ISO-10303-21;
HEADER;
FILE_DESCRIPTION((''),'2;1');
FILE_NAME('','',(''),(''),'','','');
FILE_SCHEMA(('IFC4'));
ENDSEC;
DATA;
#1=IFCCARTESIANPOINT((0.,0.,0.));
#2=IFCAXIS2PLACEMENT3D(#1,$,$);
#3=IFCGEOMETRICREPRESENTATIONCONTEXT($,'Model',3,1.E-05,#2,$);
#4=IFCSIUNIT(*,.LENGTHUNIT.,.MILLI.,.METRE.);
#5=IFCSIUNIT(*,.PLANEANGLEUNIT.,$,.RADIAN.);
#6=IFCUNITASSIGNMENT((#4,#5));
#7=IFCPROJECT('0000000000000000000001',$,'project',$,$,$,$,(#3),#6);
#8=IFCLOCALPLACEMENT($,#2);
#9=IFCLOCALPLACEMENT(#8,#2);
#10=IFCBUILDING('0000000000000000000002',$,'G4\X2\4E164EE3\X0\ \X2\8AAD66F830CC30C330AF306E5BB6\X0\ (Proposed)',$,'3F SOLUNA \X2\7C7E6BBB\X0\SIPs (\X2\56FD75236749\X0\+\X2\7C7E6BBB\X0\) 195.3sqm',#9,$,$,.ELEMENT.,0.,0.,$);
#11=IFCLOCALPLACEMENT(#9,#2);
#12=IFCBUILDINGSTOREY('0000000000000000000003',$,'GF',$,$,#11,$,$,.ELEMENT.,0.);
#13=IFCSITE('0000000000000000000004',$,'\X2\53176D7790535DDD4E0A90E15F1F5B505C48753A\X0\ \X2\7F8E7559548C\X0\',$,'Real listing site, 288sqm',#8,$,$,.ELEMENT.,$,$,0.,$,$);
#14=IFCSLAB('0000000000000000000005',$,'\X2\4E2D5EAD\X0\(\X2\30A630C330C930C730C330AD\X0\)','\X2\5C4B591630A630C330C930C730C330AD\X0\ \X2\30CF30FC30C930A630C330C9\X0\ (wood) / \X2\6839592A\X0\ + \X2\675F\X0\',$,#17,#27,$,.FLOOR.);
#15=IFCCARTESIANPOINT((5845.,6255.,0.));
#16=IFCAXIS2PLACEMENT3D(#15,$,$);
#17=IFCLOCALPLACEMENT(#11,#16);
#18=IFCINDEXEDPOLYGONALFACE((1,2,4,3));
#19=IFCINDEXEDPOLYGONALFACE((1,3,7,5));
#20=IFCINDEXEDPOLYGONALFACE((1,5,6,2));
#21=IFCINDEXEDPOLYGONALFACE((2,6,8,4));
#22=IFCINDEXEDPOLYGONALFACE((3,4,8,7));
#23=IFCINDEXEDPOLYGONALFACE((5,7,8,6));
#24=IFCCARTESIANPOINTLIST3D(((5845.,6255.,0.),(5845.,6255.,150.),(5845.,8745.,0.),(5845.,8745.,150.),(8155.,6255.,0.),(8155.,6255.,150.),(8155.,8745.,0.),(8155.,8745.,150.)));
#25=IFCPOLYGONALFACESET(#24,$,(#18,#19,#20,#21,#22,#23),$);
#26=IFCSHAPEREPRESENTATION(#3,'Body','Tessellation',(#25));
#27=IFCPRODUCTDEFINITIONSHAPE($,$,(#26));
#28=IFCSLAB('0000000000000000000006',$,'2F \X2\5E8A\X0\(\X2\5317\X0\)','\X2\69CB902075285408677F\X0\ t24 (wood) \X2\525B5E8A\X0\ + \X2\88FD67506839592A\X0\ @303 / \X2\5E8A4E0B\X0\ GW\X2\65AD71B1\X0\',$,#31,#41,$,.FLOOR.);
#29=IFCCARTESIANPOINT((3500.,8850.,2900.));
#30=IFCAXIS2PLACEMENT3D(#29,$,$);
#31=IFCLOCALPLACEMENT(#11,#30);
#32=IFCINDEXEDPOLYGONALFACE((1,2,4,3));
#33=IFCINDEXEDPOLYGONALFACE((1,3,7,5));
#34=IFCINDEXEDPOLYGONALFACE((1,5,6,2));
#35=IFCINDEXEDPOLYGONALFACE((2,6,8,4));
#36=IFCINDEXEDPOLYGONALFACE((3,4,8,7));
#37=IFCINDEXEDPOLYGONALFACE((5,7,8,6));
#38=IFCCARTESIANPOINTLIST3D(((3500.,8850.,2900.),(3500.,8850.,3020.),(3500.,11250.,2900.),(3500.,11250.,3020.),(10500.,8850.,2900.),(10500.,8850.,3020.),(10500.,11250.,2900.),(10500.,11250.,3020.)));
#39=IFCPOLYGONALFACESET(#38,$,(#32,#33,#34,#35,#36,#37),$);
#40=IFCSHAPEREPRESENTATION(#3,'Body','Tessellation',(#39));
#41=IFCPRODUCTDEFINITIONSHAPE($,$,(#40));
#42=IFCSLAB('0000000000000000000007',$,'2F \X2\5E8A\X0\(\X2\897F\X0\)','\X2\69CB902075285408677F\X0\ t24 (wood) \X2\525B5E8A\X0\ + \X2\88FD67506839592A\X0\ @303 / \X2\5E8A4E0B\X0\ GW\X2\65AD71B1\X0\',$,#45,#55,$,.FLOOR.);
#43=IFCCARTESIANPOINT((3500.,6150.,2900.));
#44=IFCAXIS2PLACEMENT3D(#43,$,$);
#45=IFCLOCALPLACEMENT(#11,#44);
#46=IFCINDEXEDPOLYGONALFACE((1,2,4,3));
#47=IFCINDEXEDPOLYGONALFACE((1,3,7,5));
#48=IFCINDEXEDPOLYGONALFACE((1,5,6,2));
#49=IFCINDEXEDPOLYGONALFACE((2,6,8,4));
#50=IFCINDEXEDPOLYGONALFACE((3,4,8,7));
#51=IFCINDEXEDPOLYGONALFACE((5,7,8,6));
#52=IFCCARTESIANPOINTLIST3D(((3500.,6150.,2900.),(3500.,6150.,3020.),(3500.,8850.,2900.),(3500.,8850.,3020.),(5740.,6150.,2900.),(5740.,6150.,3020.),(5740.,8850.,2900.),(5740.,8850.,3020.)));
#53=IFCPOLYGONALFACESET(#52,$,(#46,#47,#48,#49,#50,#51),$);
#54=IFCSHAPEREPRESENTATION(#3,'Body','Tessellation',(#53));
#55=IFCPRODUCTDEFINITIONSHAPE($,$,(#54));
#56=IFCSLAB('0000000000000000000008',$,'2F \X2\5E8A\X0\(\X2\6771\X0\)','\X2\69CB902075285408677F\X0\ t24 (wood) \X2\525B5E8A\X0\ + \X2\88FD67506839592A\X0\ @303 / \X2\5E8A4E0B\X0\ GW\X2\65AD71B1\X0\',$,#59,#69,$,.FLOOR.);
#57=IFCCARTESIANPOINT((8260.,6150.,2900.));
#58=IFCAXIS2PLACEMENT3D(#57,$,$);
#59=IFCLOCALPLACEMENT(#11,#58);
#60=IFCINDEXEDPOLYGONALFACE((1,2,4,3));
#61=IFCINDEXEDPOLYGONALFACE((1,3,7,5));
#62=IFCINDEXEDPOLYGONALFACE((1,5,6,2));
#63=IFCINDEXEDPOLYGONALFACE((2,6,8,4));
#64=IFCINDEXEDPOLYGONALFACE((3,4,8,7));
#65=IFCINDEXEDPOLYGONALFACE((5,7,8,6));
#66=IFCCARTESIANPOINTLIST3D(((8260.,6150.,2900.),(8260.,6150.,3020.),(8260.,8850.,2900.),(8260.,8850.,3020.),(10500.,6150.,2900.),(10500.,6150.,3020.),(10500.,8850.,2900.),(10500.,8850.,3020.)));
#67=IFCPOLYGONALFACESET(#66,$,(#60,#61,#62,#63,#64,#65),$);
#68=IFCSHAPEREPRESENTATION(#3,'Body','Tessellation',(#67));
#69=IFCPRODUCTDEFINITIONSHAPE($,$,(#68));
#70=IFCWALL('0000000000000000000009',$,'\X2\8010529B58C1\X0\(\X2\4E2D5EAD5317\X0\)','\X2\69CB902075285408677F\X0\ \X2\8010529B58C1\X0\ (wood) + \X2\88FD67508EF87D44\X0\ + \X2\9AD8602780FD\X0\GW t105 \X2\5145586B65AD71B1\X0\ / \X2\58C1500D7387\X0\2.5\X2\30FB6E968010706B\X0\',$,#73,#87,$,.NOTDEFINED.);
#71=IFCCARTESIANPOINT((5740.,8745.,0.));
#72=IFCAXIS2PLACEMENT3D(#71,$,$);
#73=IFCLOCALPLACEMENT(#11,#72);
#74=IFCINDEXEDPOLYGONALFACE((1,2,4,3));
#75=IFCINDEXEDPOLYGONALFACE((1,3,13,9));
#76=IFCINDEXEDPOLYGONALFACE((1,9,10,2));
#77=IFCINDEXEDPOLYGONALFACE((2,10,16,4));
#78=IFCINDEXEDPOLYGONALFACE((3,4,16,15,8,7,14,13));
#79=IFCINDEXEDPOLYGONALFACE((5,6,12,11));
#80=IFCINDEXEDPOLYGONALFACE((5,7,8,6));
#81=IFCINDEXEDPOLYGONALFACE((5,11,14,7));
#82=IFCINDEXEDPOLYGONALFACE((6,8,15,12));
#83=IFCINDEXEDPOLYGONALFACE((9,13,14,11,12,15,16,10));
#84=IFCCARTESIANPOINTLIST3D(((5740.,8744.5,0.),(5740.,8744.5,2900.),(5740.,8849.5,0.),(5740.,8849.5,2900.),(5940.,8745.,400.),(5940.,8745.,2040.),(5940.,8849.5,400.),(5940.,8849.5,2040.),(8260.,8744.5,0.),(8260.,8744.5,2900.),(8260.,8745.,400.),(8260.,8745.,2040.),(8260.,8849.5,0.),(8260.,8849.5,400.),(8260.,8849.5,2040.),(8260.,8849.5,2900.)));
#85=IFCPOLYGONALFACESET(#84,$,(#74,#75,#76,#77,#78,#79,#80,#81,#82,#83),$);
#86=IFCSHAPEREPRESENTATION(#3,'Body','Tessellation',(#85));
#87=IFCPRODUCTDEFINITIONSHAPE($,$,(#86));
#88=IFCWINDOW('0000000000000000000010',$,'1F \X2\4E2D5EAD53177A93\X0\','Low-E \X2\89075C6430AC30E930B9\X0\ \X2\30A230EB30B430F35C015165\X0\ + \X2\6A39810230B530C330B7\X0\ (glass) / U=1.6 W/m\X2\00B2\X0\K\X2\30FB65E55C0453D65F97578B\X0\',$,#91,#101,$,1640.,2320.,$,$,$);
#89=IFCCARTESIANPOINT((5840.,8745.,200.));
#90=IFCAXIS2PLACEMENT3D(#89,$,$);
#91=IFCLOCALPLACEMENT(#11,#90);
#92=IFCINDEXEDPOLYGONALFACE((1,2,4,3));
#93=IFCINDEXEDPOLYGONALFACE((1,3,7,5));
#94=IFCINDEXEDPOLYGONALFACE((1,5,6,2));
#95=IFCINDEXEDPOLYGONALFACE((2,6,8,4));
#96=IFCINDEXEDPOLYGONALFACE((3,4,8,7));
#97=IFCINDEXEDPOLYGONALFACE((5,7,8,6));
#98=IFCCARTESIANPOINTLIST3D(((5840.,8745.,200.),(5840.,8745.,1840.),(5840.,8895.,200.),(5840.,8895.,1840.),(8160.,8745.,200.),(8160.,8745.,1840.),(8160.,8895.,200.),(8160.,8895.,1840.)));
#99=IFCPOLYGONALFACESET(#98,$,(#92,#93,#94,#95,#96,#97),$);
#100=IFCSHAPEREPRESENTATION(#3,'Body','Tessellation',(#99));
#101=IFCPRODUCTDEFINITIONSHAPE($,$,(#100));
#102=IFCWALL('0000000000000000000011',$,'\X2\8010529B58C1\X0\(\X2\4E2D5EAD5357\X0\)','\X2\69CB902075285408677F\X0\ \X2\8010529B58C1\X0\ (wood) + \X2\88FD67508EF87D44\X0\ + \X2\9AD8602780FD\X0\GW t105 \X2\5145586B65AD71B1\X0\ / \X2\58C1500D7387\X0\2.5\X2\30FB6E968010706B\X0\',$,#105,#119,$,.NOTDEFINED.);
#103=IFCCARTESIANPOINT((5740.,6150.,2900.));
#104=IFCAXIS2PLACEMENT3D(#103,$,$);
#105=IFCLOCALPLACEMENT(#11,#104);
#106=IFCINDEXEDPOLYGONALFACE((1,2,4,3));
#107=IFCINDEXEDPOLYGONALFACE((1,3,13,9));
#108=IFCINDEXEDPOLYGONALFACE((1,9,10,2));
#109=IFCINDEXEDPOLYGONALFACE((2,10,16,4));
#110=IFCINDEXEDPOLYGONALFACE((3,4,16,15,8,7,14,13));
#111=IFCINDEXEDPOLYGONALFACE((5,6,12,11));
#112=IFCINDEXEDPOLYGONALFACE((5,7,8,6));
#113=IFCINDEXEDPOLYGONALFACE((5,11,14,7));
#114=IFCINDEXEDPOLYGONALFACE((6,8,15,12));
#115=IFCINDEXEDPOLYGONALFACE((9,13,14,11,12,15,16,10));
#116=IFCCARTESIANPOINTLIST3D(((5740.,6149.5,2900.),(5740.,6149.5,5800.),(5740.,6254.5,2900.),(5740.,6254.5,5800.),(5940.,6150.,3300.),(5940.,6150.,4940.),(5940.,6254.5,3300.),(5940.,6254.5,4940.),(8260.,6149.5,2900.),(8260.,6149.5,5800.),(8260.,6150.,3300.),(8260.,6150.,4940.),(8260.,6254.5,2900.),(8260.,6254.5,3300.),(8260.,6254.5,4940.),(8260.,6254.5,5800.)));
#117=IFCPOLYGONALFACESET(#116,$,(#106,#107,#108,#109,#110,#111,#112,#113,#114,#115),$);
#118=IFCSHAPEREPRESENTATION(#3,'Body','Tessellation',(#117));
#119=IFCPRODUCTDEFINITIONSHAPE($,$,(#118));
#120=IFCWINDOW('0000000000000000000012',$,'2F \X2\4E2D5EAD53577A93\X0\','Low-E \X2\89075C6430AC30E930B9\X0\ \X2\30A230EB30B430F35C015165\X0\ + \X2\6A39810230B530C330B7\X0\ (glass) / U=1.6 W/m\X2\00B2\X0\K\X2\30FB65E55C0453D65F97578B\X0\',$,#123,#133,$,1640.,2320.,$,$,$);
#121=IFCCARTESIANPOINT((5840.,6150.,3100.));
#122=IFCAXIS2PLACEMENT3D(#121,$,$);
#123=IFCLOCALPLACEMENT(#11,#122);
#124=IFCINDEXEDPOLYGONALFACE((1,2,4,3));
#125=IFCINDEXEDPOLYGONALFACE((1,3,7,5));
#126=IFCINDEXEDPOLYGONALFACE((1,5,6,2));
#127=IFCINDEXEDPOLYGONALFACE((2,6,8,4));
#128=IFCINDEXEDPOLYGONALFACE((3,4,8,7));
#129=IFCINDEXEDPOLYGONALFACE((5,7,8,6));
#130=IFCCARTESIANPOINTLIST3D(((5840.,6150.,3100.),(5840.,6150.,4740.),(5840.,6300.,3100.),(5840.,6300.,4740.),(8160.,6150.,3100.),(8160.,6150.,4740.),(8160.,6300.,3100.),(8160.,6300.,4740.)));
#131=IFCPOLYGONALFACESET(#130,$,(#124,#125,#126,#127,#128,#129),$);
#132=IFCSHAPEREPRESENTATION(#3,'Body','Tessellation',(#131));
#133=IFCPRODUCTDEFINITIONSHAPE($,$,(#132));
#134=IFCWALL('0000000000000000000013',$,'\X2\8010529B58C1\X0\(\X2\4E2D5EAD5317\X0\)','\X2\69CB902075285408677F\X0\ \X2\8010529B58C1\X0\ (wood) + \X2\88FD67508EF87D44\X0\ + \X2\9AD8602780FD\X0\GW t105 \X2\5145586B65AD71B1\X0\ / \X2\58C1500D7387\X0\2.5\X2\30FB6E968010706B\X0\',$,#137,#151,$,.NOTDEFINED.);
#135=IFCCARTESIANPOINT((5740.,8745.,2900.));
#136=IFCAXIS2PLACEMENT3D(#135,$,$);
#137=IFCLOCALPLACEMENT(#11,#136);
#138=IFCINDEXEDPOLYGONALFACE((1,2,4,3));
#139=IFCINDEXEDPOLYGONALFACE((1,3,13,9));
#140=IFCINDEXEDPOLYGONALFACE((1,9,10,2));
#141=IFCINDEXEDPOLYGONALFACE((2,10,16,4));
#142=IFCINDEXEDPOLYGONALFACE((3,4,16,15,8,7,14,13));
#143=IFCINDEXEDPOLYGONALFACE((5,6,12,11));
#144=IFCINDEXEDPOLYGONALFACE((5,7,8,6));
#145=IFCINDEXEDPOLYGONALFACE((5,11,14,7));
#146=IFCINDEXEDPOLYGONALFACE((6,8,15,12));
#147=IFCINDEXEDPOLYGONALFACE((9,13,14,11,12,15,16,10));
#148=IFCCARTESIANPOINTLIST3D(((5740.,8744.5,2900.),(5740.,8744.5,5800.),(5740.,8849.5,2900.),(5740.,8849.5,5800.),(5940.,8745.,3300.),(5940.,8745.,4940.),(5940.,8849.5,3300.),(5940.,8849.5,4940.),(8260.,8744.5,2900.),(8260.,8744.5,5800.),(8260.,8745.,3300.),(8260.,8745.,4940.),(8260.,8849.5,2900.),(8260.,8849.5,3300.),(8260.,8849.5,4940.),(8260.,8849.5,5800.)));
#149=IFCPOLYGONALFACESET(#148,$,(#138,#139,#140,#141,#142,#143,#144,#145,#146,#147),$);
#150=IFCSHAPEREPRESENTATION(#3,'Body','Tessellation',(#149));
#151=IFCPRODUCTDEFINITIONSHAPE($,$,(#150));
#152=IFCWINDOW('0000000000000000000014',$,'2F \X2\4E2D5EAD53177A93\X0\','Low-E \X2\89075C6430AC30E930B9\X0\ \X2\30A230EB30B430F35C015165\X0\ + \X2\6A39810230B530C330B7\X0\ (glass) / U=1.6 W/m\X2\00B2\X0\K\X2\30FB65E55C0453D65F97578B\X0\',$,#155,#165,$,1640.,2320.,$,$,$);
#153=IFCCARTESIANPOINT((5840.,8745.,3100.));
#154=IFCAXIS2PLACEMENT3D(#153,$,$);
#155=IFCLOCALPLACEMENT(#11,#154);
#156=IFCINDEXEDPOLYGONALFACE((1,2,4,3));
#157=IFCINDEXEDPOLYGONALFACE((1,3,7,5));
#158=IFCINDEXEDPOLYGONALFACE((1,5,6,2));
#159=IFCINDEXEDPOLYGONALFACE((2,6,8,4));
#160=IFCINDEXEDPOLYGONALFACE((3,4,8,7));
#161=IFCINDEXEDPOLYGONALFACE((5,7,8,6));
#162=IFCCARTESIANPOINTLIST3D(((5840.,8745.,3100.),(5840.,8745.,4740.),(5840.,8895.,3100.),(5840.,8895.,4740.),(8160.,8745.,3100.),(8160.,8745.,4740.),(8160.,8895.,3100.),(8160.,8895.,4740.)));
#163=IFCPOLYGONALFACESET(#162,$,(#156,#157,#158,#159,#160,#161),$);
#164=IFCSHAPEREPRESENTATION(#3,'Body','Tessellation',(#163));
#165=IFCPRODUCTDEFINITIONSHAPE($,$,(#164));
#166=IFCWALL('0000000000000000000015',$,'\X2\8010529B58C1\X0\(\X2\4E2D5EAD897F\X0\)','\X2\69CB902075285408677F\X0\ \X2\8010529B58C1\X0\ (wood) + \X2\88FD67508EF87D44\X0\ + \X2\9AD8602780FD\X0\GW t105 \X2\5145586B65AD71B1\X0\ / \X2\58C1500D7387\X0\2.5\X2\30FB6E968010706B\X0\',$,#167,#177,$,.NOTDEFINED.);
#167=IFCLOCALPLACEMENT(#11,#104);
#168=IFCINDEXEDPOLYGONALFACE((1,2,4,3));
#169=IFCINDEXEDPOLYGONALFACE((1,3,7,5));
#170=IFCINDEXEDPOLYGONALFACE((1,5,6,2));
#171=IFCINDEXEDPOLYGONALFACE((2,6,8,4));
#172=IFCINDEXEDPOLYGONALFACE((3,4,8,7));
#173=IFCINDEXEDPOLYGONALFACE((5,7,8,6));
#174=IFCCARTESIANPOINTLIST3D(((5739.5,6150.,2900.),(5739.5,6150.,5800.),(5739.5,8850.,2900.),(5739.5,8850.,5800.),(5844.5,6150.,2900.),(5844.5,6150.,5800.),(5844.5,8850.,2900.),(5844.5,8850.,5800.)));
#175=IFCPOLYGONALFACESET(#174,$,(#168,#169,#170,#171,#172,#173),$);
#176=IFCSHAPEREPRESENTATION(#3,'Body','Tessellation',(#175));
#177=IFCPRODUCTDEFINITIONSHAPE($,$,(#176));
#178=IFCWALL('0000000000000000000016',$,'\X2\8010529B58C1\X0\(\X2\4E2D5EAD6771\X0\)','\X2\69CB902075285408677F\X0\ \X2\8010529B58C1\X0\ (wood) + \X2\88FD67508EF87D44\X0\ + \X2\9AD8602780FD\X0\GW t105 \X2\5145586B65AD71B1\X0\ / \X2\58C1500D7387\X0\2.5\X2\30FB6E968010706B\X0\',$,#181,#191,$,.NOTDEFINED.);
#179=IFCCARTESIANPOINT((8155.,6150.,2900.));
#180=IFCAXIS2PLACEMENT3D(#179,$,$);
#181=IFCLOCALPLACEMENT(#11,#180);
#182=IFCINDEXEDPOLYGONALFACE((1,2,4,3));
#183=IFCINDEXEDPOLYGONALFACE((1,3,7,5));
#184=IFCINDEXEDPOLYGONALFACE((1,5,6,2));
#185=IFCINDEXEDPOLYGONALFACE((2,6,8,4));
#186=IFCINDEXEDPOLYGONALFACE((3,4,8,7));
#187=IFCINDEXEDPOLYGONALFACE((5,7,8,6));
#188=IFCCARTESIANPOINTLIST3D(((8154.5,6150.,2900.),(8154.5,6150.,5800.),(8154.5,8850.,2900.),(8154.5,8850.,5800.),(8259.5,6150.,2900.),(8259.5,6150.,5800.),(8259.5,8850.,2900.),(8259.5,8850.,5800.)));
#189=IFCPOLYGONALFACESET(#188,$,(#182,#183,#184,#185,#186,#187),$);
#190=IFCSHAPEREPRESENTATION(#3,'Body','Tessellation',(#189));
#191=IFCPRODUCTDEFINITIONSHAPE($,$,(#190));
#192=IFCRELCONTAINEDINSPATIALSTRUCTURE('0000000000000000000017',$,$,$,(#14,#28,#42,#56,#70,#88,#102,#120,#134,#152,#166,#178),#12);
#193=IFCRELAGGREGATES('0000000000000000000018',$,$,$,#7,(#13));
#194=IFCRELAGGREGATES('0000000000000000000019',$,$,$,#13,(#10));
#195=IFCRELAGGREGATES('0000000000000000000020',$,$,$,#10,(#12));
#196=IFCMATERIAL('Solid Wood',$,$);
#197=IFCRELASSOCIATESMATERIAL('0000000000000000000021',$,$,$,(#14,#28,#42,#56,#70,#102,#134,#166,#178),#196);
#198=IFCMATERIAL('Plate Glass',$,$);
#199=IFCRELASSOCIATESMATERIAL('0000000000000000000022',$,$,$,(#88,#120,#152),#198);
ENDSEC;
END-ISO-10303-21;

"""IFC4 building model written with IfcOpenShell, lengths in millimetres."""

from ifc_helpers import new_model, si_unit, frame, frame_2d, origin, place, context, project, spatial, rectangle, extrude, material, element, fill, save


model = new_model("IFC4")

# Units and contexts
model_context = context("Model", 3, precision=1e-05, world=origin())
ifc_project = project(units=[si_unit("LENGTHUNIT", "METRE", prefix="MILLI"), si_unit("PLANEANGLEUNIT", "RADIAN")], contexts=[model_context])

# Site, building, storey
site_placement = place(None, origin())
site = spatial("IfcSite", under=ifc_project, at=site_placement, Name="北海道川上郡弟子屈町 美留和", ObjectType="Real listing site, 288sqm", CompositionType="ELEMENT", RefElevation=0.0)
building_placement = place(site_placement, origin())
building = spatial("IfcBuilding", under=site, at=building_placement, Name="G4世代 読書ヌックの家 (Proposed)", ObjectType="3F SOLUNA 籾殻SIPs (国産杉+籾殻) 195.3sqm", CompositionType="ELEMENT", ElevationOfRefHeight=0.0, ElevationOfTerrain=0.0)
storey_placement = place(building_placement, origin())
storey = spatial("IfcBuildingStorey", under=building, at=storey_placement, Name="GF", CompositionType="ELEMENT", Elevation=0.0)

# Slabs
ifc_material_1 = material(Name="Solid Wood")
slab_1_placement = place(storey_placement, frame((5845.0, 6255.0, 0.0)))
element("IfcSlab", 1, at=slab_1_placement, inside=storey, material=ifc_material_1, Name="中庭(ウッドデッキ)", Description="屋外ウッドデッキ ハードウッド (wood) / 根太 + 束", PredefinedType="FLOOR", context=model_context, shape_type="SweptSolid", body=[
    extrude(rectangle(XDim=2310.0, YDim=2490.0, at=frame_2d((1155.0, 1245.0))), frame((5845.0, 6255.0, 0.0)), (0.0, 0.0, 1.0), 150.0),
])
slab_2_placement = place(storey_placement, frame((3500.0, 8850.0, 2900.0)))
element("IfcSlab", 2, at=slab_2_placement, inside=storey, material=ifc_material_1, Name="2F 床(北)", Description="構造用合板 t24 (wood) 剛床 + 製材根太 @303 / 床下 GW断熱", PredefinedType="FLOOR", context=model_context, shape_type="SweptSolid", body=[
    extrude(rectangle(XDim=7000.0, YDim=2400.0, at=frame_2d((3500.0, 1200.0))), frame((3500.0, 8850.0, 2900.0)), (0.0, 0.0, 1.0), 120.0),
])
slab_3_placement = place(storey_placement, frame((3500.0, 6150.0, 2900.0)))
element("IfcSlab", 3, at=slab_3_placement, inside=storey, material=ifc_material_1, Name="2F 床(西)", Description="構造用合板 t24 (wood) 剛床 + 製材根太 @303 / 床下 GW断熱", PredefinedType="FLOOR", context=model_context, shape_type="SweptSolid", body=[
    extrude(rectangle(XDim=2240.0, YDim=2700.0, at=frame_2d((1120.0, 1350.0))), frame((3500.0, 6150.0, 2900.0)), (0.0, 0.0, 1.0), 120.0),
])
slab_4_placement = place(storey_placement, frame((8260.0, 6150.0, 2900.0)))
element("IfcSlab", 4, at=slab_4_placement, inside=storey, material=ifc_material_1, Name="2F 床(東)", Description="構造用合板 t24 (wood) 剛床 + 製材根太 @303 / 床下 GW断熱", PredefinedType="FLOOR", context=model_context, shape_type="SweptSolid", body=[
    extrude(rectangle(XDim=2240.0, YDim=2700.0, at=frame_2d((1120.0, 1350.0))), frame((8260.0, 6150.0, 2900.0)), (0.0, 0.0, 1.0), 120.0),
])

# Wall, opening, window
wall_1_placement = place(storey_placement, frame((5740.0, 8745.0, 0.0)))
wall_1 = element("IfcWall", 5, at=wall_1_placement, inside=storey, material=ifc_material_1, Name="耐力壁(中庭北)", Description="構造用合板 耐力壁 (wood) + 製材軸組 + 高性能GW t105 充填断熱 / 壁倍率2.5・準耐火", PredefinedType="NOTDEFINED", context=model_context, shape_type="SweptSolid", body=[
    extrude(rectangle(XDim=2520.0, YDim=105.0, at=frame_2d((1260.0, 52.0))), frame((5740.0, 8745.0, 0.0)), (0.0, 0.0, 1.0), 2900.0),
])
opening_1_placement = place(storey_placement, frame((5840.0, 8745.0, 200.0)))
opening_1 = element("IfcOpeningElement", 6, at=opening_1_placement, cuts=wall_1, PredefinedType="NOTDEFINED", context=model_context, shape_type="SweptSolid", body=[
    extrude(rectangle(XDim=2320.0, YDim=150.0, at=frame_2d((1160.0, 75.0))), frame((5840.0, 8745.0, 200.0)), (0.0, 0.0, 1.0), 1640.0),
])
ifc_material_2 = material(Name="Plate Glass")
window_1_placement = place(storey_placement, frame((5840.0, 8745.0, 200.0)))
window_1 = element("IfcWindow", 7, at=window_1_placement, inside=storey, material=ifc_material_2, Name="1F 中庭北窓", Description="Low-E 複層ガラス アルゴン封入 + 樹脂サッシ (glass) / U=1.6 W/m²K・日射取得型", OverallHeight=1640.0, OverallWidth=2320.0, context=model_context, shape_type="SweptSolid", body=[
    extrude(rectangle(XDim=2320.0, YDim=150.0, at=frame_2d((1160.0, 75.0))), frame((5840.0, 8745.0, 200.0)), (0.0, 0.0, 1.0), 1640.0),
])
fill(opening_1, window_1)

# Walls, openings, windows
wall_2_placement = place(storey_placement, frame((5740.0, 6150.0, 2900.0)))
wall_2 = element("IfcWall", 8, at=wall_2_placement, inside=storey, material=ifc_material_1, Name="耐力壁(中庭南)", Description="構造用合板 耐力壁 (wood) + 製材軸組 + 高性能GW t105 充填断熱 / 壁倍率2.5・準耐火", PredefinedType="NOTDEFINED", context=model_context, shape_type="SweptSolid", body=[
    extrude(rectangle(XDim=2520.0, YDim=105.0, at=frame_2d((1260.0, 52.0))), frame((5740.0, 6150.0, 2900.0)), (0.0, 0.0, 1.0), 2900.0),
])
opening_2_placement = place(storey_placement, frame((5840.0, 6150.0, 3100.0)))
opening_2 = element("IfcOpeningElement", 9, at=opening_2_placement, cuts=wall_2, PredefinedType="NOTDEFINED", context=model_context, shape_type="SweptSolid", body=[
    extrude(rectangle(XDim=2320.0, YDim=150.0, at=frame_2d((1160.0, 75.0))), frame((5840.0, 6150.0, 3100.0)), (0.0, 0.0, 1.0), 1640.0),
])
window_2_placement = place(storey_placement, frame((5840.0, 6150.0, 3100.0)))
window_2 = element("IfcWindow", 10, at=window_2_placement, inside=storey, material=ifc_material_2, Name="2F 中庭南窓", Description="Low-E 複層ガラス アルゴン封入 + 樹脂サッシ (glass) / U=1.6 W/m²K・日射取得型", OverallHeight=1640.0, OverallWidth=2320.0, context=model_context, shape_type="SweptSolid", body=[
    extrude(rectangle(XDim=2320.0, YDim=150.0, at=frame_2d((1160.0, 75.0))), frame((5840.0, 6150.0, 3100.0)), (0.0, 0.0, 1.0), 1640.0),
])
fill(opening_2, window_2)
wall_3_placement = place(storey_placement, frame((5740.0, 8745.0, 2900.0)))
wall_3 = element("IfcWall", 11, at=wall_3_placement, inside=storey, material=ifc_material_1, Name="耐力壁(中庭北)", Description="構造用合板 耐力壁 (wood) + 製材軸組 + 高性能GW t105 充填断熱 / 壁倍率2.5・準耐火", PredefinedType="NOTDEFINED", context=model_context, shape_type="SweptSolid", body=[
    extrude(rectangle(XDim=2520.0, YDim=105.0, at=frame_2d((1260.0, 52.0))), frame((5740.0, 8745.0, 2900.0)), (0.0, 0.0, 1.0), 2900.0),
])
opening_3_placement = place(storey_placement, frame((5840.0, 8745.0, 3100.0)))
opening_3 = element("IfcOpeningElement", 12, at=opening_3_placement, cuts=wall_3, PredefinedType="NOTDEFINED", context=model_context, shape_type="SweptSolid", body=[
    extrude(rectangle(XDim=2320.0, YDim=150.0, at=frame_2d((1160.0, 75.0))), frame((5840.0, 8745.0, 3100.0)), (0.0, 0.0, 1.0), 1640.0),
])
window_3_placement = place(storey_placement, frame((5840.0, 8745.0, 3100.0)))
window_3 = element("IfcWindow", 13, at=window_3_placement, inside=storey, material=ifc_material_2, Name="2F 中庭北窓", Description="Low-E 複層ガラス アルゴン封入 + 樹脂サッシ (glass) / U=1.6 W/m²K・日射取得型", OverallHeight=1640.0, OverallWidth=2320.0, context=model_context, shape_type="SweptSolid", body=[
    extrude(rectangle(XDim=2320.0, YDim=150.0, at=frame_2d((1160.0, 75.0))), frame((5840.0, 8745.0, 3100.0)), (0.0, 0.0, 1.0), 1640.0),
])
fill(opening_3, window_3)

# Walls
wall_4_placement = place(storey_placement, frame((5740.0, 6150.0, 2900.0)))
element("IfcWall", 14, at=wall_4_placement, inside=storey, material=ifc_material_1, Name="耐力壁(中庭西)", Description="構造用合板 耐力壁 (wood) + 製材軸組 + 高性能GW t105 充填断熱 / 壁倍率2.5・準耐火", PredefinedType="NOTDEFINED", context=model_context, shape_type="SweptSolid", body=[
    extrude(rectangle(XDim=105.0, YDim=2700.0, at=frame_2d((52.0, 1350.0))), frame((5740.0, 6150.0, 2900.0)), (0.0, 0.0, 1.0), 2900.0),
])
wall_5_placement = place(storey_placement, frame((8155.0, 6150.0, 2900.0)))
element("IfcWall", 15, at=wall_5_placement, inside=storey, material=ifc_material_1, Name="耐力壁(中庭東)", Description="構造用合板 耐力壁 (wood) + 製材軸組 + 高性能GW t105 充填断熱 / 壁倍率2.5・準耐火", PredefinedType="NOTDEFINED", context=model_context, shape_type="SweptSolid", body=[
    extrude(rectangle(XDim=105.0, YDim=2700.0, at=frame_2d((52.0, 1350.0))), frame((8155.0, 6150.0, 2900.0)), (0.0, 0.0, 1.0), 2900.0),
])

save(model, "model.ifc")
